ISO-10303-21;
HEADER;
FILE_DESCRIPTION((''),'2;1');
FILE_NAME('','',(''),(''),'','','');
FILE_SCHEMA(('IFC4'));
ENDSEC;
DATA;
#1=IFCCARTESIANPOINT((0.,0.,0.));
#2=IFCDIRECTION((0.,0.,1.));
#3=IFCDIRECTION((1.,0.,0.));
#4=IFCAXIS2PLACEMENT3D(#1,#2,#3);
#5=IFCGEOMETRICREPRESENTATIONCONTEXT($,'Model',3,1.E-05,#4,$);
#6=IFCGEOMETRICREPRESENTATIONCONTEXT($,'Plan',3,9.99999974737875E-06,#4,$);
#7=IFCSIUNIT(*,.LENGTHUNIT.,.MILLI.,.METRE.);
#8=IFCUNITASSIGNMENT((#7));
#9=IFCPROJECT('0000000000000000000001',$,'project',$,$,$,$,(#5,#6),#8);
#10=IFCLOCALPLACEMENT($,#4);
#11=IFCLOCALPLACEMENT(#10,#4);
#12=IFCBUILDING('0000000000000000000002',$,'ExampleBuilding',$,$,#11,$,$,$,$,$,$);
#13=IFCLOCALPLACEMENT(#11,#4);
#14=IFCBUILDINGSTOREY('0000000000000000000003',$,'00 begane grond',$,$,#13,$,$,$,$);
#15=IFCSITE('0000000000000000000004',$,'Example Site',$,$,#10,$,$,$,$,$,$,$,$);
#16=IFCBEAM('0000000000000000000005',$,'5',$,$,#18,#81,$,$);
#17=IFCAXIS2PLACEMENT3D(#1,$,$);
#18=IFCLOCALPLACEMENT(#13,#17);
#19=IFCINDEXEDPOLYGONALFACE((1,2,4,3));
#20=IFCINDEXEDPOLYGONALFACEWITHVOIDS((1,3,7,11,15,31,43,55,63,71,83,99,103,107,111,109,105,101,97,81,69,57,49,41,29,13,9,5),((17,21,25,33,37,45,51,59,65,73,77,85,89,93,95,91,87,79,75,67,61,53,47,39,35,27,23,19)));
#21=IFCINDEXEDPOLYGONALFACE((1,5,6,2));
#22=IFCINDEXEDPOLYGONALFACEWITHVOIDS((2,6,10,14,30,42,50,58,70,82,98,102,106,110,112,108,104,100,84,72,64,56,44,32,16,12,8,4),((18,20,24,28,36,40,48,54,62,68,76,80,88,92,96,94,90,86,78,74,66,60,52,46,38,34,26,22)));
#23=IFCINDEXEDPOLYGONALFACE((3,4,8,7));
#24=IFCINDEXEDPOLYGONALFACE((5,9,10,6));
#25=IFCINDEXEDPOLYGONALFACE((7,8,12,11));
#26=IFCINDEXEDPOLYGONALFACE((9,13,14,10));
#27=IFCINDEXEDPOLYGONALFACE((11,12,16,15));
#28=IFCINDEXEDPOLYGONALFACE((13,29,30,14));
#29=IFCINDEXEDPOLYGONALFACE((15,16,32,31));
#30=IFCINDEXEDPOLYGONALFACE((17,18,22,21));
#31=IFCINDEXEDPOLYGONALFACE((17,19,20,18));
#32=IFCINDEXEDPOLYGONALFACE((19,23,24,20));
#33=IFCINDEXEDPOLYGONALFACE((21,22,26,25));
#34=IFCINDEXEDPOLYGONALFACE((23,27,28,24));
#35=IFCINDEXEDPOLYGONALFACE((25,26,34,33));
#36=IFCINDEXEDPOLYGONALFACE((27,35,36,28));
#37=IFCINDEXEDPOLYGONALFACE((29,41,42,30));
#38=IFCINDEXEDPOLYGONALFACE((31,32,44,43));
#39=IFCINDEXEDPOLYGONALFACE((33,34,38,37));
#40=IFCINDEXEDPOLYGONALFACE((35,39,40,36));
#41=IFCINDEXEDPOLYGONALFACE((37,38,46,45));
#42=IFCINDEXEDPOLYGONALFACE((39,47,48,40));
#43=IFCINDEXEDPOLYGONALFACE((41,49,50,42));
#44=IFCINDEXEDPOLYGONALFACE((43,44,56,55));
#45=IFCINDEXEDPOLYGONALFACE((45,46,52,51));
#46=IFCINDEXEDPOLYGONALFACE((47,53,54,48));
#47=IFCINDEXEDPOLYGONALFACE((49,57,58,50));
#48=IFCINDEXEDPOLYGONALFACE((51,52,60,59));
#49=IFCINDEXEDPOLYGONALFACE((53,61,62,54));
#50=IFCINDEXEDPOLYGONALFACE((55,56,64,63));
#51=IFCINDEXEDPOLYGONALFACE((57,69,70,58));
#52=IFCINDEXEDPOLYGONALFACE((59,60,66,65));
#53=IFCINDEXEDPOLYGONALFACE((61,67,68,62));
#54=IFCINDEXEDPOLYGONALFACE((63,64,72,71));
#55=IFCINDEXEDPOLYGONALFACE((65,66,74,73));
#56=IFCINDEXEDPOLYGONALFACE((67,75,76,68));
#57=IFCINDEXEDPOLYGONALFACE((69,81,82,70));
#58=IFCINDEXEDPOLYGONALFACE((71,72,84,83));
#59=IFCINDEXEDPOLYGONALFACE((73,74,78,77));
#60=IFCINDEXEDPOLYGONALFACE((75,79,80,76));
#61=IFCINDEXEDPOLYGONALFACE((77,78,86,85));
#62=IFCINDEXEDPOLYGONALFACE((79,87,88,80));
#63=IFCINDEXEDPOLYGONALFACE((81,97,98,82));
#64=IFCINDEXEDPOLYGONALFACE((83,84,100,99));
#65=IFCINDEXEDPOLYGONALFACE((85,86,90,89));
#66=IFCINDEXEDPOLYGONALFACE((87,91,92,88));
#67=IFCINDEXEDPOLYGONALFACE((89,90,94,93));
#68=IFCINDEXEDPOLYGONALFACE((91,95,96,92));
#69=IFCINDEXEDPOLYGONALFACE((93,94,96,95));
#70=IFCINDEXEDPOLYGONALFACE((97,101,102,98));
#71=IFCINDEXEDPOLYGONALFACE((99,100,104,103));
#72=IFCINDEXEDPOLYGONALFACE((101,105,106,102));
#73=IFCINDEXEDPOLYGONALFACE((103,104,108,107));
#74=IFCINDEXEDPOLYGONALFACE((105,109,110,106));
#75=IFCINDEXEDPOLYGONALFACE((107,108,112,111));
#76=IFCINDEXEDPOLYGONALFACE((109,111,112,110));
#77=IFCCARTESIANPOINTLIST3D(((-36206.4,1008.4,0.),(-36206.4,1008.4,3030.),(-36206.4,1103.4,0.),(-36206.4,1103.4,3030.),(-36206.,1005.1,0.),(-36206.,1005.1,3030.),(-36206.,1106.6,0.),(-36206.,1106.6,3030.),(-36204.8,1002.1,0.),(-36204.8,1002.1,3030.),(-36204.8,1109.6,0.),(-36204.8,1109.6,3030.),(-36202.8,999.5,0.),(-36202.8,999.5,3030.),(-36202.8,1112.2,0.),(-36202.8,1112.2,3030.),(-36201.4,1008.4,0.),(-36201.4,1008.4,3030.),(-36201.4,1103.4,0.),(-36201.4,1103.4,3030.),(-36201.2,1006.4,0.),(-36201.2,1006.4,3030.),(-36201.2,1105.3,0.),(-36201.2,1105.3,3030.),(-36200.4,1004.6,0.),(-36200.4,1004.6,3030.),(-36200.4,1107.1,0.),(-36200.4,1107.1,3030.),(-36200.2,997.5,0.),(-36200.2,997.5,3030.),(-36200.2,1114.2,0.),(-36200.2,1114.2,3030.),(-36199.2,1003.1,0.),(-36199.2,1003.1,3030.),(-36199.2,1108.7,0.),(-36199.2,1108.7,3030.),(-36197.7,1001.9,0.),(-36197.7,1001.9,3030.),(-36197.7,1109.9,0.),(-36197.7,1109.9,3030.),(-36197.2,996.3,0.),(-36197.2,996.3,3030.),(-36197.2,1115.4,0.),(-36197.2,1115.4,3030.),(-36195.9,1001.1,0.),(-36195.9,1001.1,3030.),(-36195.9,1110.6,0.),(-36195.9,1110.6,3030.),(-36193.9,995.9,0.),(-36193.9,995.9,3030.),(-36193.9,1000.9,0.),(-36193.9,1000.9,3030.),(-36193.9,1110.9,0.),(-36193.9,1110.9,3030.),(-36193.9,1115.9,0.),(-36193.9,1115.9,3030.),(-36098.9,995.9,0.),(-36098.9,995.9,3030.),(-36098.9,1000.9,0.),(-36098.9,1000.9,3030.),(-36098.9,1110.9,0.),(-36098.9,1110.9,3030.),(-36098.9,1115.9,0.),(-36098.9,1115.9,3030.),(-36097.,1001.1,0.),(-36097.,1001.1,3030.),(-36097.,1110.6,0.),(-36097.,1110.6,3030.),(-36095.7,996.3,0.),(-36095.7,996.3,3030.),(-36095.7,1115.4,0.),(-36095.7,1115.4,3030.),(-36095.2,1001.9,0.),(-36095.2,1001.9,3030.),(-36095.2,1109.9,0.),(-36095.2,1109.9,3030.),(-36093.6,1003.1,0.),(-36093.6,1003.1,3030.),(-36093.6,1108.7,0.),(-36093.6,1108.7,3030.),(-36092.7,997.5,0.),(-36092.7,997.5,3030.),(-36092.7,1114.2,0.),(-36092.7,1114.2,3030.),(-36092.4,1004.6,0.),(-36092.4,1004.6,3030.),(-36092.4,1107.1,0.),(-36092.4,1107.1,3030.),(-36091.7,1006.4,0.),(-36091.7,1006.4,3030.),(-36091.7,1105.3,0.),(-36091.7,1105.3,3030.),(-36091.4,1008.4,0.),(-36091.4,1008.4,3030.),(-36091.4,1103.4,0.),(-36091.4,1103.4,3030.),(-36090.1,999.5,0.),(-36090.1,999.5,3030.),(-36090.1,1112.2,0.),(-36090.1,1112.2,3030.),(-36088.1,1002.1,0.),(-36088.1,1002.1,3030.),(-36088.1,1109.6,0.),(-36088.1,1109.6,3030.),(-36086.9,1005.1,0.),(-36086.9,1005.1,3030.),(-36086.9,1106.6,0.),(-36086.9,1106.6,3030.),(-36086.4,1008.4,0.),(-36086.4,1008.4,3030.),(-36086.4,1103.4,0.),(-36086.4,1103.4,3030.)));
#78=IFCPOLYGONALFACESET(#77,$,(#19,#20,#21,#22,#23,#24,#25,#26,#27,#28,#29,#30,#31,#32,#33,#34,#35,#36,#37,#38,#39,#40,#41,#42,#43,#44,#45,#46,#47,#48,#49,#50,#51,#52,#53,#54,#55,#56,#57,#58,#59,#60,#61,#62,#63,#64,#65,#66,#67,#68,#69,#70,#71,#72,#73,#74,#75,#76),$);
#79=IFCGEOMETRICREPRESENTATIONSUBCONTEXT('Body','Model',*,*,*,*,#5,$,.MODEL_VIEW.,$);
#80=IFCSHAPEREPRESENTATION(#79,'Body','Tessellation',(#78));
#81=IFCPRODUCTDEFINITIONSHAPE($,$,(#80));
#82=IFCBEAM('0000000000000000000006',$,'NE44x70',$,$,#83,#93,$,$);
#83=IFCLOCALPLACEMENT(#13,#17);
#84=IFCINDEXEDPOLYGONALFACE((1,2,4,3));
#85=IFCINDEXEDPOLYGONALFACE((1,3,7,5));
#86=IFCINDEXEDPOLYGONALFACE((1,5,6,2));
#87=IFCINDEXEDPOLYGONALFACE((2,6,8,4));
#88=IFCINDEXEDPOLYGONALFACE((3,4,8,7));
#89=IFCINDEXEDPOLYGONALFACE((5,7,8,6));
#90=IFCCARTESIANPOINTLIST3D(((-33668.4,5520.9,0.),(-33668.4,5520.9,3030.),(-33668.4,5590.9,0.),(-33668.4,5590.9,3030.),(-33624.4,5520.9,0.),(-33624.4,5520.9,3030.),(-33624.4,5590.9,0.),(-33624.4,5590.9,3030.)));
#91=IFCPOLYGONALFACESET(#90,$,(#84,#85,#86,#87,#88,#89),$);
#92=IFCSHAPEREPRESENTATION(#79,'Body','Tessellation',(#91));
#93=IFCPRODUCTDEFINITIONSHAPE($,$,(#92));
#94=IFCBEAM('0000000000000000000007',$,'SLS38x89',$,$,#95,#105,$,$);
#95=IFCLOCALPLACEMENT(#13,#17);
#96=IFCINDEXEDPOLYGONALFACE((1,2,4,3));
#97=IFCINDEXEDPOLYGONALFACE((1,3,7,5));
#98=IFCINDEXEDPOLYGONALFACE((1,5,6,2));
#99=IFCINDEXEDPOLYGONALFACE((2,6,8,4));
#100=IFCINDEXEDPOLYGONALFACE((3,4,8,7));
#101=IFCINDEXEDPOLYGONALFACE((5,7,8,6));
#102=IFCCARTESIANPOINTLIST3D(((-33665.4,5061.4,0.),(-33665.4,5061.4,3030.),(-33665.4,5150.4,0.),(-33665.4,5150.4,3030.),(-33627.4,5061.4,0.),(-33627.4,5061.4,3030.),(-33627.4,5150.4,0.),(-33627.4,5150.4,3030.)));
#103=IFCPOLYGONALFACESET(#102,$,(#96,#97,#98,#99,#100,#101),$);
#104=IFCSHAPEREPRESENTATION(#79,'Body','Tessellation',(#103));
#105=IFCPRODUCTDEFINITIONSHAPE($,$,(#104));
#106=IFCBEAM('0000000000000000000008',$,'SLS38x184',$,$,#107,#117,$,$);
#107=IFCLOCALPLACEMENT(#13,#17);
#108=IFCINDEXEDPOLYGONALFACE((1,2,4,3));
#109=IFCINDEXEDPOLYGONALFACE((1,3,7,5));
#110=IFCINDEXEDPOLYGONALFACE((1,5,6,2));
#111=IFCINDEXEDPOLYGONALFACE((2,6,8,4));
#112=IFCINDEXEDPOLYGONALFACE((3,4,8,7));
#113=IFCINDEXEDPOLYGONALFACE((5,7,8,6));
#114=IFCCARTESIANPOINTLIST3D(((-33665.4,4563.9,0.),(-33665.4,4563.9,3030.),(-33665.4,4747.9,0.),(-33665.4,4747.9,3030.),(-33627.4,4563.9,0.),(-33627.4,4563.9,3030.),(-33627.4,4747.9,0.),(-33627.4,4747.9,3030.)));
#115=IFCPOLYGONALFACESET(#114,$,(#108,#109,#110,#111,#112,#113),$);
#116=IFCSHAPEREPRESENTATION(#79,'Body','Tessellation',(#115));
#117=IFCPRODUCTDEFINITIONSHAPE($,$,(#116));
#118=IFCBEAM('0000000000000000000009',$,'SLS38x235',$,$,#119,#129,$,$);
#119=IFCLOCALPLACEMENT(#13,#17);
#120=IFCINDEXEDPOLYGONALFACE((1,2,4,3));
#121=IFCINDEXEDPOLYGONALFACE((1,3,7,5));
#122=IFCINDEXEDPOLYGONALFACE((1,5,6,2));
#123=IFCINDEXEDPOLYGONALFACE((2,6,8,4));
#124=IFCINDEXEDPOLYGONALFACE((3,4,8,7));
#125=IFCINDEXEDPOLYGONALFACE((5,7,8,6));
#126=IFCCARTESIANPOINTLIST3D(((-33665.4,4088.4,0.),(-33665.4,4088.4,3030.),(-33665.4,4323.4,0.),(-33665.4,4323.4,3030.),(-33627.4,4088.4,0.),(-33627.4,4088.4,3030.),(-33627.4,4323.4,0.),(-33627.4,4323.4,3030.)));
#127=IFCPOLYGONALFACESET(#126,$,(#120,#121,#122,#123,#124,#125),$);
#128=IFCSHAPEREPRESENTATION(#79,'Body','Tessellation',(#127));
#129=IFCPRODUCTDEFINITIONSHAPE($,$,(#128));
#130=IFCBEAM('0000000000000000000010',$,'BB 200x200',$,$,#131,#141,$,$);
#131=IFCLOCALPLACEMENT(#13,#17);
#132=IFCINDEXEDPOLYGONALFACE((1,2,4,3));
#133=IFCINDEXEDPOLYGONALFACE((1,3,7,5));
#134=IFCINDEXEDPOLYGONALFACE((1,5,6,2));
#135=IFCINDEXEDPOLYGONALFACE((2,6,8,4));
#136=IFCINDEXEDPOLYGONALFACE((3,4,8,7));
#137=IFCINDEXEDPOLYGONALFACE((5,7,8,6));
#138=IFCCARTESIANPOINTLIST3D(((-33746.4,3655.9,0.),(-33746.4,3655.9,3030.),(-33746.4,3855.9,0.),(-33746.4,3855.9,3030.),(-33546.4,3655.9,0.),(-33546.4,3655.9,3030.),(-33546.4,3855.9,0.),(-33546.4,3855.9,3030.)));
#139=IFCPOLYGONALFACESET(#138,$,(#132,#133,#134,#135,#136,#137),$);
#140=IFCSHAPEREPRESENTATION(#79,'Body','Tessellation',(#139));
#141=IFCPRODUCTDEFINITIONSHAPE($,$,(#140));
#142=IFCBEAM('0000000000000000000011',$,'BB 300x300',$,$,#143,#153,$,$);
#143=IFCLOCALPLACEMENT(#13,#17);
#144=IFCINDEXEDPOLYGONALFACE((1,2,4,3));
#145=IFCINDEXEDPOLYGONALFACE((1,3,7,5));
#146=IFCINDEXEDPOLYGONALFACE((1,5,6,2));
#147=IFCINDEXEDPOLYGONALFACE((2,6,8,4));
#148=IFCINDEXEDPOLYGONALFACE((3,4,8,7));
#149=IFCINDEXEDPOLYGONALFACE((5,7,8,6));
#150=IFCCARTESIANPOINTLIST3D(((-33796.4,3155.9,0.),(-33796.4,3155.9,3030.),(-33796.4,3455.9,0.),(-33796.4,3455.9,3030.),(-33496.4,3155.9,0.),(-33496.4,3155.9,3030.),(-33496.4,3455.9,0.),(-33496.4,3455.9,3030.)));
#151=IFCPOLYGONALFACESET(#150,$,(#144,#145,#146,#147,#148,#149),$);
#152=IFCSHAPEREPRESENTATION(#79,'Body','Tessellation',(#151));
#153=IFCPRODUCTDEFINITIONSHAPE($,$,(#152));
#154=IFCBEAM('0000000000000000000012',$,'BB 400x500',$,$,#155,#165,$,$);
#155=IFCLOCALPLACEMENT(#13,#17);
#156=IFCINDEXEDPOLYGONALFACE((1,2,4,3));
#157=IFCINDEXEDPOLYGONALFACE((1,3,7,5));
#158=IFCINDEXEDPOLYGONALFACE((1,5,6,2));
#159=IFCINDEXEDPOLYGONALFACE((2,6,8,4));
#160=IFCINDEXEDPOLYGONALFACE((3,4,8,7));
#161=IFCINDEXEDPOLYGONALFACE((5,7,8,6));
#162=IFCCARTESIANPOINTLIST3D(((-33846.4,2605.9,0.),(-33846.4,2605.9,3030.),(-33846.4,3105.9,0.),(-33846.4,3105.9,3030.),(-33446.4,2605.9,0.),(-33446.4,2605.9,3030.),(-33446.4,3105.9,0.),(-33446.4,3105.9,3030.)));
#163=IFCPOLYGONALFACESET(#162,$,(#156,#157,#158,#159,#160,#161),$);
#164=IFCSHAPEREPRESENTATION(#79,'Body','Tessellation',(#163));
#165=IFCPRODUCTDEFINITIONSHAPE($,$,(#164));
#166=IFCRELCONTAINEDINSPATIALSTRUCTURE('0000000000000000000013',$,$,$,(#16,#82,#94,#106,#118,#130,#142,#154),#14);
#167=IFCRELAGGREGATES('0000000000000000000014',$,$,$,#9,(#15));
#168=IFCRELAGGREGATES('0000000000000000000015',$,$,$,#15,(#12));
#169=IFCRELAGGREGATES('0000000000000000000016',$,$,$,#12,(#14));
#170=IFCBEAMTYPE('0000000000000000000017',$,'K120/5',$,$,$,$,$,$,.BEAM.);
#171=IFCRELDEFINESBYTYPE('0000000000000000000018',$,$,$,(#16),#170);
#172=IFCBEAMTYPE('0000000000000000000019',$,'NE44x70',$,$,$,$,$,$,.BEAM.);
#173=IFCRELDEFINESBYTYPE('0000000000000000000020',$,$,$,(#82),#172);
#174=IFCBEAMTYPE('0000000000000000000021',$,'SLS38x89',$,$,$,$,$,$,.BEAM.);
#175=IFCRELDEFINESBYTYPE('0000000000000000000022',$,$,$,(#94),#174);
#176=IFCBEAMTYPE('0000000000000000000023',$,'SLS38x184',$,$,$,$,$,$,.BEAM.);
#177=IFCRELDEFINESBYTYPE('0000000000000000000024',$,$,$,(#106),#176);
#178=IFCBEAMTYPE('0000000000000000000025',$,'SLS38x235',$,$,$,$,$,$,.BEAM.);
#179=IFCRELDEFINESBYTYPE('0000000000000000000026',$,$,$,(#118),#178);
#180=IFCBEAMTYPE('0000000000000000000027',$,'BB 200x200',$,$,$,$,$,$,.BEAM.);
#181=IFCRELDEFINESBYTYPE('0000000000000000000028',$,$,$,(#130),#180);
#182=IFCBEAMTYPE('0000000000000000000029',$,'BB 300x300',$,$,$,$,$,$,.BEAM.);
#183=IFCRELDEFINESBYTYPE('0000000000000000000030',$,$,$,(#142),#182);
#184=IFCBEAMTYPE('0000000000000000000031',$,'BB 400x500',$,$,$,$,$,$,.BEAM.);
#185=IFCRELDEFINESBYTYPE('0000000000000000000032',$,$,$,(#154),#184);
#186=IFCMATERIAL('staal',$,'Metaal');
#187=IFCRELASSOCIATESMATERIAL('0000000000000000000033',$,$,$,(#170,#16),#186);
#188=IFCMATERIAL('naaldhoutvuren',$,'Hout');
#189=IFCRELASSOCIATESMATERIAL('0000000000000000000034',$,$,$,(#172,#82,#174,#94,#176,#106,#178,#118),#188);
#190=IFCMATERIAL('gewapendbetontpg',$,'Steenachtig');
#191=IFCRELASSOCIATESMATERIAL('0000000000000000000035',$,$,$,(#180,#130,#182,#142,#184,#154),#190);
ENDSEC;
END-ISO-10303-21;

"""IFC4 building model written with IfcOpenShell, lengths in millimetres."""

from ifc_helpers import new_model, si_unit, frame, origin_with_axes, place, context, subcontext, project, spatial, rectangle, hollow_rectangle, extrude, material, material_profile, profile_set, profile_usage, type_object, element, save


model = new_model("IFC4")

# Units and contexts
model_context = context("Model", 3, precision=1e-05, world=origin_with_axes())
plan_context = context("Plan", 3, precision=9.99999974737875e-06, world=origin_with_axes())
body_context = subcontext(model_context, "Body", "Model", "MODEL_VIEW")
ifc_project = project(units=[si_unit("LENGTHUNIT", "METRE", prefix="MILLI")], contexts=[model_context, plan_context])

# Site, building, storey
site_placement = place(None, frame((0.0, 0.0, 0.0), z_axis=(0.0, 0.0, 1.0), x_axis=(1.0, 0.0, 0.0)))
site = spatial("IfcSite", under=ifc_project, at=site_placement, Name="Example Site")
building_placement = place(site_placement, frame((0.0, 0.0, 0.0), z_axis=(0.0, 0.0, 1.0), x_axis=(1.0, 0.0, 0.0)))
building = spatial("IfcBuilding", under=site, at=building_placement, Name="ExampleBuilding")
storey_placement = place(building_placement, frame((0.0, 0.0, 0.0), z_axis=(0.0, 0.0, 1.0), x_axis=(1.0, 0.0, 0.0)))
storey = spatial("IfcBuildingStorey", under=building, at=storey_placement, Name="00 begane grond")

# Beams
ifc_material_1 = material(Name="staal", Category="Metaal")
ifc_material_profile_1 = material_profile(ifc_material_1, hollow_rectangle(XDim=120.0, YDim=120.0, WallThickness=5.0, InnerFilletRadius=7.5, OuterFilletRadius=12.5))
ifc_profile_set_1 = profile_set([ifc_material_profile_1], Name="staal")
ifc_profile_usage_1 = profile_usage(ifc_profile_set_1)
beam_type_1 = type_object("IfcBeamType", Name="K120/5", PredefinedType="BEAM", material=ifc_profile_set_1)
beam_1_placement = place(storey_placement, frame((-36146.4, 1055.9, 0.0), z_axis=(-0.000001, 0.0, 1.0), x_axis=(1.0, 0.0, 0.000001)))
element("IfcBeam", 1, at=beam_1_placement, inside=storey, type_object=beam_type_1, material=ifc_profile_usage_1, Name="5", context=body_context, shape_type="SweptSolid", body=[
    extrude(hollow_rectangle(XDim=120.0, YDim=120.0, WallThickness=5.0, InnerFilletRadius=7.5, OuterFilletRadius=12.5), origin_with_axes(), (0.0, 0.0, 1.0), 3030.0),
])
ifc_material_2 = material(Name="naaldhoutvuren", Category="Hout")
ifc_material_profile_2 = material_profile(ifc_material_2, rectangle(XDim=44.0, YDim=70.0, kind="CURVE"))
ifc_profile_set_2 = profile_set([ifc_material_profile_2], Name="naaldhoutvuren")
ifc_profile_usage_2 = profile_usage(ifc_profile_set_2)
beam_type_2 = type_object("IfcBeamType", Name="NE44x70", PredefinedType="BEAM", material=ifc_profile_set_2)
beam_2_placement = place(storey_placement, frame((-33646.4, 5555.9, 0.0), z_axis=(-0.000001, 0.0, 1.0), x_axis=(1.0, 0.0, 0.000001)))
element("IfcBeam", 2, at=beam_2_placement, inside=storey, type_object=beam_type_2, material=ifc_profile_usage_2, Name="NE44x70", context=body_context, shape_type="SweptSolid", body=[
    extrude(rectangle(XDim=44.0, YDim=70.0, kind="CURVE"), origin_with_axes(), (0.0, 0.0, 1.0), 3030.0),
])
ifc_material_profile_3 = material_profile(ifc_material_2, rectangle(XDim=38.0, YDim=89.0, kind="CURVE"))
ifc_profile_set_3 = profile_set([ifc_material_profile_3], Name="naaldhoutvuren")
ifc_profile_usage_3 = profile_usage(ifc_profile_set_3)
beam_type_3 = type_object("IfcBeamType", Name="SLS38x89", PredefinedType="BEAM", material=ifc_profile_set_3)
beam_3_placement = place(storey_placement, frame((-33646.4, 5105.9, 0.0), z_axis=(-0.000001, 0.0, 1.0), x_axis=(1.0, 0.0, 0.000001)))
element("IfcBeam", 3, at=beam_3_placement, inside=storey, type_object=beam_type_3, material=ifc_profile_usage_3, Name="SLS38x89", context=body_context, shape_type="SweptSolid", body=[
    extrude(rectangle(XDim=38.0, YDim=89.0, kind="CURVE"), origin_with_axes(), (0.0, 0.0, 1.0), 3030.0),
])
ifc_material_profile_4 = material_profile(ifc_material_2, rectangle(XDim=38.0, YDim=184.0, kind="CURVE"))
ifc_profile_set_4 = profile_set([ifc_material_profile_4], Name="naaldhoutvuren")
ifc_profile_usage_4 = profile_usage(ifc_profile_set_4)
beam_type_4 = type_object("IfcBeamType", Name="SLS38x184", PredefinedType="BEAM", material=ifc_profile_set_4)
beam_4_placement = place(storey_placement, frame((-33646.4, 4655.9, 0.0), z_axis=(-0.000001, 0.0, 1.0), x_axis=(1.0, 0.0, 0.000001)))
element("IfcBeam", 4, at=beam_4_placement, inside=storey, type_object=beam_type_4, material=ifc_profile_usage_4, Name="SLS38x184", context=body_context, shape_type="SweptSolid", body=[
    extrude(rectangle(XDim=38.0, YDim=184.0, kind="CURVE"), origin_with_axes(), (0.0, 0.0, 1.0), 3030.0),
])
ifc_material_profile_5 = material_profile(ifc_material_2, rectangle(XDim=38.0, YDim=235.0, kind="CURVE"))
ifc_profile_set_5 = profile_set([ifc_material_profile_5], Name="naaldhoutvuren")
ifc_profile_usage_5 = profile_usage(ifc_profile_set_5)
beam_type_5 = type_object("IfcBeamType", Name="SLS38x235", PredefinedType="BEAM", material=ifc_profile_set_5)
beam_5_placement = place(storey_placement, frame((-33646.4, 4205.9, 0.0), z_axis=(-0.000001, 0.0, 1.0), x_axis=(1.0, 0.0, 0.000001)))
element("IfcBeam", 5, at=beam_5_placement, inside=storey, type_object=beam_type_5, material=ifc_profile_usage_5, Name="SLS38x235", context=body_context, shape_type="SweptSolid", body=[
    extrude(rectangle(XDim=38.0, YDim=235.0, kind="CURVE"), origin_with_axes(), (0.0, 0.0, 1.0), 3030.0),
])
ifc_material_3 = material(Name="gewapendbetontpg", Category="Steenachtig")
ifc_material_profile_6 = material_profile(ifc_material_3, rectangle(XDim=200.0, YDim=200.0))
ifc_profile_set_6 = profile_set([ifc_material_profile_6], Name="gewapendbetontpg")
ifc_profile_usage_6 = profile_usage(ifc_profile_set_6, cardinal=5)
beam_type_6 = type_object("IfcBeamType", Name="BB 200x200", PredefinedType="BEAM", material=ifc_profile_set_6)
beam_6_placement = place(storey_placement, frame((-33646.4, 3755.9, 0.0), z_axis=(-0.000001, 0.0, 1.0), x_axis=(1.0, 0.0, 0.000001)))
element("IfcBeam", 6, at=beam_6_placement, inside=storey, type_object=beam_type_6, material=ifc_profile_usage_6, Name="BB 200x200", context=body_context, shape_type="SweptSolid", body=[
    extrude(rectangle(XDim=200.0, YDim=200.0), origin_with_axes(), (0.0, 0.0, 1.0), 3030.0),
])
ifc_material_profile_7 = material_profile(ifc_material_3, rectangle(XDim=300.0, YDim=300.0))
ifc_profile_set_7 = profile_set([ifc_material_profile_7], Name="gewapendbetontpg")
ifc_profile_usage_7 = profile_usage(ifc_profile_set_7, cardinal=5)
beam_type_7 = type_object("IfcBeamType", Name="BB 300x300", PredefinedType="BEAM", material=ifc_profile_set_7)
beam_7_placement = place(storey_placement, frame((-33646.4, 3305.9, 0.0), z_axis=(-0.000001, 0.0, 1.0), x_axis=(1.0, 0.0, 0.000001)))
element("IfcBeam", 7, at=beam_7_placement, inside=storey, type_object=beam_type_7, material=ifc_profile_usage_7, Name="BB 300x300", context=body_context, shape_type="SweptSolid", body=[
    extrude(rectangle(XDim=300.0, YDim=300.0), origin_with_axes(), (0.0, 0.0, 1.0), 3030.0),
])
ifc_material_profile_8 = material_profile(ifc_material_3, rectangle(XDim=400.0, YDim=500.0))
ifc_profile_set_8 = profile_set([ifc_material_profile_8], Name="gewapendbetontpg")
ifc_profile_usage_8 = profile_usage(ifc_profile_set_8, cardinal=5)
beam_type_8 = type_object("IfcBeamType", Name="BB 400x500", PredefinedType="BEAM", material=ifc_profile_set_8)
beam_8_placement = place(storey_placement, frame((-33646.4, 2855.9, 0.0), z_axis=(-0.000001, 0.0, 1.0), x_axis=(1.0, 0.0, 0.000001)))
element("IfcBeam", 8, at=beam_8_placement, inside=storey, type_object=beam_type_8, material=ifc_profile_usage_8, Name="BB 400x500", context=body_context, shape_type="SweptSolid", body=[
    extrude(rectangle(XDim=400.0, YDim=500.0), origin_with_axes(), (0.0, 0.0, 1.0), 3030.0),
])

save(model, "model.ifc")
